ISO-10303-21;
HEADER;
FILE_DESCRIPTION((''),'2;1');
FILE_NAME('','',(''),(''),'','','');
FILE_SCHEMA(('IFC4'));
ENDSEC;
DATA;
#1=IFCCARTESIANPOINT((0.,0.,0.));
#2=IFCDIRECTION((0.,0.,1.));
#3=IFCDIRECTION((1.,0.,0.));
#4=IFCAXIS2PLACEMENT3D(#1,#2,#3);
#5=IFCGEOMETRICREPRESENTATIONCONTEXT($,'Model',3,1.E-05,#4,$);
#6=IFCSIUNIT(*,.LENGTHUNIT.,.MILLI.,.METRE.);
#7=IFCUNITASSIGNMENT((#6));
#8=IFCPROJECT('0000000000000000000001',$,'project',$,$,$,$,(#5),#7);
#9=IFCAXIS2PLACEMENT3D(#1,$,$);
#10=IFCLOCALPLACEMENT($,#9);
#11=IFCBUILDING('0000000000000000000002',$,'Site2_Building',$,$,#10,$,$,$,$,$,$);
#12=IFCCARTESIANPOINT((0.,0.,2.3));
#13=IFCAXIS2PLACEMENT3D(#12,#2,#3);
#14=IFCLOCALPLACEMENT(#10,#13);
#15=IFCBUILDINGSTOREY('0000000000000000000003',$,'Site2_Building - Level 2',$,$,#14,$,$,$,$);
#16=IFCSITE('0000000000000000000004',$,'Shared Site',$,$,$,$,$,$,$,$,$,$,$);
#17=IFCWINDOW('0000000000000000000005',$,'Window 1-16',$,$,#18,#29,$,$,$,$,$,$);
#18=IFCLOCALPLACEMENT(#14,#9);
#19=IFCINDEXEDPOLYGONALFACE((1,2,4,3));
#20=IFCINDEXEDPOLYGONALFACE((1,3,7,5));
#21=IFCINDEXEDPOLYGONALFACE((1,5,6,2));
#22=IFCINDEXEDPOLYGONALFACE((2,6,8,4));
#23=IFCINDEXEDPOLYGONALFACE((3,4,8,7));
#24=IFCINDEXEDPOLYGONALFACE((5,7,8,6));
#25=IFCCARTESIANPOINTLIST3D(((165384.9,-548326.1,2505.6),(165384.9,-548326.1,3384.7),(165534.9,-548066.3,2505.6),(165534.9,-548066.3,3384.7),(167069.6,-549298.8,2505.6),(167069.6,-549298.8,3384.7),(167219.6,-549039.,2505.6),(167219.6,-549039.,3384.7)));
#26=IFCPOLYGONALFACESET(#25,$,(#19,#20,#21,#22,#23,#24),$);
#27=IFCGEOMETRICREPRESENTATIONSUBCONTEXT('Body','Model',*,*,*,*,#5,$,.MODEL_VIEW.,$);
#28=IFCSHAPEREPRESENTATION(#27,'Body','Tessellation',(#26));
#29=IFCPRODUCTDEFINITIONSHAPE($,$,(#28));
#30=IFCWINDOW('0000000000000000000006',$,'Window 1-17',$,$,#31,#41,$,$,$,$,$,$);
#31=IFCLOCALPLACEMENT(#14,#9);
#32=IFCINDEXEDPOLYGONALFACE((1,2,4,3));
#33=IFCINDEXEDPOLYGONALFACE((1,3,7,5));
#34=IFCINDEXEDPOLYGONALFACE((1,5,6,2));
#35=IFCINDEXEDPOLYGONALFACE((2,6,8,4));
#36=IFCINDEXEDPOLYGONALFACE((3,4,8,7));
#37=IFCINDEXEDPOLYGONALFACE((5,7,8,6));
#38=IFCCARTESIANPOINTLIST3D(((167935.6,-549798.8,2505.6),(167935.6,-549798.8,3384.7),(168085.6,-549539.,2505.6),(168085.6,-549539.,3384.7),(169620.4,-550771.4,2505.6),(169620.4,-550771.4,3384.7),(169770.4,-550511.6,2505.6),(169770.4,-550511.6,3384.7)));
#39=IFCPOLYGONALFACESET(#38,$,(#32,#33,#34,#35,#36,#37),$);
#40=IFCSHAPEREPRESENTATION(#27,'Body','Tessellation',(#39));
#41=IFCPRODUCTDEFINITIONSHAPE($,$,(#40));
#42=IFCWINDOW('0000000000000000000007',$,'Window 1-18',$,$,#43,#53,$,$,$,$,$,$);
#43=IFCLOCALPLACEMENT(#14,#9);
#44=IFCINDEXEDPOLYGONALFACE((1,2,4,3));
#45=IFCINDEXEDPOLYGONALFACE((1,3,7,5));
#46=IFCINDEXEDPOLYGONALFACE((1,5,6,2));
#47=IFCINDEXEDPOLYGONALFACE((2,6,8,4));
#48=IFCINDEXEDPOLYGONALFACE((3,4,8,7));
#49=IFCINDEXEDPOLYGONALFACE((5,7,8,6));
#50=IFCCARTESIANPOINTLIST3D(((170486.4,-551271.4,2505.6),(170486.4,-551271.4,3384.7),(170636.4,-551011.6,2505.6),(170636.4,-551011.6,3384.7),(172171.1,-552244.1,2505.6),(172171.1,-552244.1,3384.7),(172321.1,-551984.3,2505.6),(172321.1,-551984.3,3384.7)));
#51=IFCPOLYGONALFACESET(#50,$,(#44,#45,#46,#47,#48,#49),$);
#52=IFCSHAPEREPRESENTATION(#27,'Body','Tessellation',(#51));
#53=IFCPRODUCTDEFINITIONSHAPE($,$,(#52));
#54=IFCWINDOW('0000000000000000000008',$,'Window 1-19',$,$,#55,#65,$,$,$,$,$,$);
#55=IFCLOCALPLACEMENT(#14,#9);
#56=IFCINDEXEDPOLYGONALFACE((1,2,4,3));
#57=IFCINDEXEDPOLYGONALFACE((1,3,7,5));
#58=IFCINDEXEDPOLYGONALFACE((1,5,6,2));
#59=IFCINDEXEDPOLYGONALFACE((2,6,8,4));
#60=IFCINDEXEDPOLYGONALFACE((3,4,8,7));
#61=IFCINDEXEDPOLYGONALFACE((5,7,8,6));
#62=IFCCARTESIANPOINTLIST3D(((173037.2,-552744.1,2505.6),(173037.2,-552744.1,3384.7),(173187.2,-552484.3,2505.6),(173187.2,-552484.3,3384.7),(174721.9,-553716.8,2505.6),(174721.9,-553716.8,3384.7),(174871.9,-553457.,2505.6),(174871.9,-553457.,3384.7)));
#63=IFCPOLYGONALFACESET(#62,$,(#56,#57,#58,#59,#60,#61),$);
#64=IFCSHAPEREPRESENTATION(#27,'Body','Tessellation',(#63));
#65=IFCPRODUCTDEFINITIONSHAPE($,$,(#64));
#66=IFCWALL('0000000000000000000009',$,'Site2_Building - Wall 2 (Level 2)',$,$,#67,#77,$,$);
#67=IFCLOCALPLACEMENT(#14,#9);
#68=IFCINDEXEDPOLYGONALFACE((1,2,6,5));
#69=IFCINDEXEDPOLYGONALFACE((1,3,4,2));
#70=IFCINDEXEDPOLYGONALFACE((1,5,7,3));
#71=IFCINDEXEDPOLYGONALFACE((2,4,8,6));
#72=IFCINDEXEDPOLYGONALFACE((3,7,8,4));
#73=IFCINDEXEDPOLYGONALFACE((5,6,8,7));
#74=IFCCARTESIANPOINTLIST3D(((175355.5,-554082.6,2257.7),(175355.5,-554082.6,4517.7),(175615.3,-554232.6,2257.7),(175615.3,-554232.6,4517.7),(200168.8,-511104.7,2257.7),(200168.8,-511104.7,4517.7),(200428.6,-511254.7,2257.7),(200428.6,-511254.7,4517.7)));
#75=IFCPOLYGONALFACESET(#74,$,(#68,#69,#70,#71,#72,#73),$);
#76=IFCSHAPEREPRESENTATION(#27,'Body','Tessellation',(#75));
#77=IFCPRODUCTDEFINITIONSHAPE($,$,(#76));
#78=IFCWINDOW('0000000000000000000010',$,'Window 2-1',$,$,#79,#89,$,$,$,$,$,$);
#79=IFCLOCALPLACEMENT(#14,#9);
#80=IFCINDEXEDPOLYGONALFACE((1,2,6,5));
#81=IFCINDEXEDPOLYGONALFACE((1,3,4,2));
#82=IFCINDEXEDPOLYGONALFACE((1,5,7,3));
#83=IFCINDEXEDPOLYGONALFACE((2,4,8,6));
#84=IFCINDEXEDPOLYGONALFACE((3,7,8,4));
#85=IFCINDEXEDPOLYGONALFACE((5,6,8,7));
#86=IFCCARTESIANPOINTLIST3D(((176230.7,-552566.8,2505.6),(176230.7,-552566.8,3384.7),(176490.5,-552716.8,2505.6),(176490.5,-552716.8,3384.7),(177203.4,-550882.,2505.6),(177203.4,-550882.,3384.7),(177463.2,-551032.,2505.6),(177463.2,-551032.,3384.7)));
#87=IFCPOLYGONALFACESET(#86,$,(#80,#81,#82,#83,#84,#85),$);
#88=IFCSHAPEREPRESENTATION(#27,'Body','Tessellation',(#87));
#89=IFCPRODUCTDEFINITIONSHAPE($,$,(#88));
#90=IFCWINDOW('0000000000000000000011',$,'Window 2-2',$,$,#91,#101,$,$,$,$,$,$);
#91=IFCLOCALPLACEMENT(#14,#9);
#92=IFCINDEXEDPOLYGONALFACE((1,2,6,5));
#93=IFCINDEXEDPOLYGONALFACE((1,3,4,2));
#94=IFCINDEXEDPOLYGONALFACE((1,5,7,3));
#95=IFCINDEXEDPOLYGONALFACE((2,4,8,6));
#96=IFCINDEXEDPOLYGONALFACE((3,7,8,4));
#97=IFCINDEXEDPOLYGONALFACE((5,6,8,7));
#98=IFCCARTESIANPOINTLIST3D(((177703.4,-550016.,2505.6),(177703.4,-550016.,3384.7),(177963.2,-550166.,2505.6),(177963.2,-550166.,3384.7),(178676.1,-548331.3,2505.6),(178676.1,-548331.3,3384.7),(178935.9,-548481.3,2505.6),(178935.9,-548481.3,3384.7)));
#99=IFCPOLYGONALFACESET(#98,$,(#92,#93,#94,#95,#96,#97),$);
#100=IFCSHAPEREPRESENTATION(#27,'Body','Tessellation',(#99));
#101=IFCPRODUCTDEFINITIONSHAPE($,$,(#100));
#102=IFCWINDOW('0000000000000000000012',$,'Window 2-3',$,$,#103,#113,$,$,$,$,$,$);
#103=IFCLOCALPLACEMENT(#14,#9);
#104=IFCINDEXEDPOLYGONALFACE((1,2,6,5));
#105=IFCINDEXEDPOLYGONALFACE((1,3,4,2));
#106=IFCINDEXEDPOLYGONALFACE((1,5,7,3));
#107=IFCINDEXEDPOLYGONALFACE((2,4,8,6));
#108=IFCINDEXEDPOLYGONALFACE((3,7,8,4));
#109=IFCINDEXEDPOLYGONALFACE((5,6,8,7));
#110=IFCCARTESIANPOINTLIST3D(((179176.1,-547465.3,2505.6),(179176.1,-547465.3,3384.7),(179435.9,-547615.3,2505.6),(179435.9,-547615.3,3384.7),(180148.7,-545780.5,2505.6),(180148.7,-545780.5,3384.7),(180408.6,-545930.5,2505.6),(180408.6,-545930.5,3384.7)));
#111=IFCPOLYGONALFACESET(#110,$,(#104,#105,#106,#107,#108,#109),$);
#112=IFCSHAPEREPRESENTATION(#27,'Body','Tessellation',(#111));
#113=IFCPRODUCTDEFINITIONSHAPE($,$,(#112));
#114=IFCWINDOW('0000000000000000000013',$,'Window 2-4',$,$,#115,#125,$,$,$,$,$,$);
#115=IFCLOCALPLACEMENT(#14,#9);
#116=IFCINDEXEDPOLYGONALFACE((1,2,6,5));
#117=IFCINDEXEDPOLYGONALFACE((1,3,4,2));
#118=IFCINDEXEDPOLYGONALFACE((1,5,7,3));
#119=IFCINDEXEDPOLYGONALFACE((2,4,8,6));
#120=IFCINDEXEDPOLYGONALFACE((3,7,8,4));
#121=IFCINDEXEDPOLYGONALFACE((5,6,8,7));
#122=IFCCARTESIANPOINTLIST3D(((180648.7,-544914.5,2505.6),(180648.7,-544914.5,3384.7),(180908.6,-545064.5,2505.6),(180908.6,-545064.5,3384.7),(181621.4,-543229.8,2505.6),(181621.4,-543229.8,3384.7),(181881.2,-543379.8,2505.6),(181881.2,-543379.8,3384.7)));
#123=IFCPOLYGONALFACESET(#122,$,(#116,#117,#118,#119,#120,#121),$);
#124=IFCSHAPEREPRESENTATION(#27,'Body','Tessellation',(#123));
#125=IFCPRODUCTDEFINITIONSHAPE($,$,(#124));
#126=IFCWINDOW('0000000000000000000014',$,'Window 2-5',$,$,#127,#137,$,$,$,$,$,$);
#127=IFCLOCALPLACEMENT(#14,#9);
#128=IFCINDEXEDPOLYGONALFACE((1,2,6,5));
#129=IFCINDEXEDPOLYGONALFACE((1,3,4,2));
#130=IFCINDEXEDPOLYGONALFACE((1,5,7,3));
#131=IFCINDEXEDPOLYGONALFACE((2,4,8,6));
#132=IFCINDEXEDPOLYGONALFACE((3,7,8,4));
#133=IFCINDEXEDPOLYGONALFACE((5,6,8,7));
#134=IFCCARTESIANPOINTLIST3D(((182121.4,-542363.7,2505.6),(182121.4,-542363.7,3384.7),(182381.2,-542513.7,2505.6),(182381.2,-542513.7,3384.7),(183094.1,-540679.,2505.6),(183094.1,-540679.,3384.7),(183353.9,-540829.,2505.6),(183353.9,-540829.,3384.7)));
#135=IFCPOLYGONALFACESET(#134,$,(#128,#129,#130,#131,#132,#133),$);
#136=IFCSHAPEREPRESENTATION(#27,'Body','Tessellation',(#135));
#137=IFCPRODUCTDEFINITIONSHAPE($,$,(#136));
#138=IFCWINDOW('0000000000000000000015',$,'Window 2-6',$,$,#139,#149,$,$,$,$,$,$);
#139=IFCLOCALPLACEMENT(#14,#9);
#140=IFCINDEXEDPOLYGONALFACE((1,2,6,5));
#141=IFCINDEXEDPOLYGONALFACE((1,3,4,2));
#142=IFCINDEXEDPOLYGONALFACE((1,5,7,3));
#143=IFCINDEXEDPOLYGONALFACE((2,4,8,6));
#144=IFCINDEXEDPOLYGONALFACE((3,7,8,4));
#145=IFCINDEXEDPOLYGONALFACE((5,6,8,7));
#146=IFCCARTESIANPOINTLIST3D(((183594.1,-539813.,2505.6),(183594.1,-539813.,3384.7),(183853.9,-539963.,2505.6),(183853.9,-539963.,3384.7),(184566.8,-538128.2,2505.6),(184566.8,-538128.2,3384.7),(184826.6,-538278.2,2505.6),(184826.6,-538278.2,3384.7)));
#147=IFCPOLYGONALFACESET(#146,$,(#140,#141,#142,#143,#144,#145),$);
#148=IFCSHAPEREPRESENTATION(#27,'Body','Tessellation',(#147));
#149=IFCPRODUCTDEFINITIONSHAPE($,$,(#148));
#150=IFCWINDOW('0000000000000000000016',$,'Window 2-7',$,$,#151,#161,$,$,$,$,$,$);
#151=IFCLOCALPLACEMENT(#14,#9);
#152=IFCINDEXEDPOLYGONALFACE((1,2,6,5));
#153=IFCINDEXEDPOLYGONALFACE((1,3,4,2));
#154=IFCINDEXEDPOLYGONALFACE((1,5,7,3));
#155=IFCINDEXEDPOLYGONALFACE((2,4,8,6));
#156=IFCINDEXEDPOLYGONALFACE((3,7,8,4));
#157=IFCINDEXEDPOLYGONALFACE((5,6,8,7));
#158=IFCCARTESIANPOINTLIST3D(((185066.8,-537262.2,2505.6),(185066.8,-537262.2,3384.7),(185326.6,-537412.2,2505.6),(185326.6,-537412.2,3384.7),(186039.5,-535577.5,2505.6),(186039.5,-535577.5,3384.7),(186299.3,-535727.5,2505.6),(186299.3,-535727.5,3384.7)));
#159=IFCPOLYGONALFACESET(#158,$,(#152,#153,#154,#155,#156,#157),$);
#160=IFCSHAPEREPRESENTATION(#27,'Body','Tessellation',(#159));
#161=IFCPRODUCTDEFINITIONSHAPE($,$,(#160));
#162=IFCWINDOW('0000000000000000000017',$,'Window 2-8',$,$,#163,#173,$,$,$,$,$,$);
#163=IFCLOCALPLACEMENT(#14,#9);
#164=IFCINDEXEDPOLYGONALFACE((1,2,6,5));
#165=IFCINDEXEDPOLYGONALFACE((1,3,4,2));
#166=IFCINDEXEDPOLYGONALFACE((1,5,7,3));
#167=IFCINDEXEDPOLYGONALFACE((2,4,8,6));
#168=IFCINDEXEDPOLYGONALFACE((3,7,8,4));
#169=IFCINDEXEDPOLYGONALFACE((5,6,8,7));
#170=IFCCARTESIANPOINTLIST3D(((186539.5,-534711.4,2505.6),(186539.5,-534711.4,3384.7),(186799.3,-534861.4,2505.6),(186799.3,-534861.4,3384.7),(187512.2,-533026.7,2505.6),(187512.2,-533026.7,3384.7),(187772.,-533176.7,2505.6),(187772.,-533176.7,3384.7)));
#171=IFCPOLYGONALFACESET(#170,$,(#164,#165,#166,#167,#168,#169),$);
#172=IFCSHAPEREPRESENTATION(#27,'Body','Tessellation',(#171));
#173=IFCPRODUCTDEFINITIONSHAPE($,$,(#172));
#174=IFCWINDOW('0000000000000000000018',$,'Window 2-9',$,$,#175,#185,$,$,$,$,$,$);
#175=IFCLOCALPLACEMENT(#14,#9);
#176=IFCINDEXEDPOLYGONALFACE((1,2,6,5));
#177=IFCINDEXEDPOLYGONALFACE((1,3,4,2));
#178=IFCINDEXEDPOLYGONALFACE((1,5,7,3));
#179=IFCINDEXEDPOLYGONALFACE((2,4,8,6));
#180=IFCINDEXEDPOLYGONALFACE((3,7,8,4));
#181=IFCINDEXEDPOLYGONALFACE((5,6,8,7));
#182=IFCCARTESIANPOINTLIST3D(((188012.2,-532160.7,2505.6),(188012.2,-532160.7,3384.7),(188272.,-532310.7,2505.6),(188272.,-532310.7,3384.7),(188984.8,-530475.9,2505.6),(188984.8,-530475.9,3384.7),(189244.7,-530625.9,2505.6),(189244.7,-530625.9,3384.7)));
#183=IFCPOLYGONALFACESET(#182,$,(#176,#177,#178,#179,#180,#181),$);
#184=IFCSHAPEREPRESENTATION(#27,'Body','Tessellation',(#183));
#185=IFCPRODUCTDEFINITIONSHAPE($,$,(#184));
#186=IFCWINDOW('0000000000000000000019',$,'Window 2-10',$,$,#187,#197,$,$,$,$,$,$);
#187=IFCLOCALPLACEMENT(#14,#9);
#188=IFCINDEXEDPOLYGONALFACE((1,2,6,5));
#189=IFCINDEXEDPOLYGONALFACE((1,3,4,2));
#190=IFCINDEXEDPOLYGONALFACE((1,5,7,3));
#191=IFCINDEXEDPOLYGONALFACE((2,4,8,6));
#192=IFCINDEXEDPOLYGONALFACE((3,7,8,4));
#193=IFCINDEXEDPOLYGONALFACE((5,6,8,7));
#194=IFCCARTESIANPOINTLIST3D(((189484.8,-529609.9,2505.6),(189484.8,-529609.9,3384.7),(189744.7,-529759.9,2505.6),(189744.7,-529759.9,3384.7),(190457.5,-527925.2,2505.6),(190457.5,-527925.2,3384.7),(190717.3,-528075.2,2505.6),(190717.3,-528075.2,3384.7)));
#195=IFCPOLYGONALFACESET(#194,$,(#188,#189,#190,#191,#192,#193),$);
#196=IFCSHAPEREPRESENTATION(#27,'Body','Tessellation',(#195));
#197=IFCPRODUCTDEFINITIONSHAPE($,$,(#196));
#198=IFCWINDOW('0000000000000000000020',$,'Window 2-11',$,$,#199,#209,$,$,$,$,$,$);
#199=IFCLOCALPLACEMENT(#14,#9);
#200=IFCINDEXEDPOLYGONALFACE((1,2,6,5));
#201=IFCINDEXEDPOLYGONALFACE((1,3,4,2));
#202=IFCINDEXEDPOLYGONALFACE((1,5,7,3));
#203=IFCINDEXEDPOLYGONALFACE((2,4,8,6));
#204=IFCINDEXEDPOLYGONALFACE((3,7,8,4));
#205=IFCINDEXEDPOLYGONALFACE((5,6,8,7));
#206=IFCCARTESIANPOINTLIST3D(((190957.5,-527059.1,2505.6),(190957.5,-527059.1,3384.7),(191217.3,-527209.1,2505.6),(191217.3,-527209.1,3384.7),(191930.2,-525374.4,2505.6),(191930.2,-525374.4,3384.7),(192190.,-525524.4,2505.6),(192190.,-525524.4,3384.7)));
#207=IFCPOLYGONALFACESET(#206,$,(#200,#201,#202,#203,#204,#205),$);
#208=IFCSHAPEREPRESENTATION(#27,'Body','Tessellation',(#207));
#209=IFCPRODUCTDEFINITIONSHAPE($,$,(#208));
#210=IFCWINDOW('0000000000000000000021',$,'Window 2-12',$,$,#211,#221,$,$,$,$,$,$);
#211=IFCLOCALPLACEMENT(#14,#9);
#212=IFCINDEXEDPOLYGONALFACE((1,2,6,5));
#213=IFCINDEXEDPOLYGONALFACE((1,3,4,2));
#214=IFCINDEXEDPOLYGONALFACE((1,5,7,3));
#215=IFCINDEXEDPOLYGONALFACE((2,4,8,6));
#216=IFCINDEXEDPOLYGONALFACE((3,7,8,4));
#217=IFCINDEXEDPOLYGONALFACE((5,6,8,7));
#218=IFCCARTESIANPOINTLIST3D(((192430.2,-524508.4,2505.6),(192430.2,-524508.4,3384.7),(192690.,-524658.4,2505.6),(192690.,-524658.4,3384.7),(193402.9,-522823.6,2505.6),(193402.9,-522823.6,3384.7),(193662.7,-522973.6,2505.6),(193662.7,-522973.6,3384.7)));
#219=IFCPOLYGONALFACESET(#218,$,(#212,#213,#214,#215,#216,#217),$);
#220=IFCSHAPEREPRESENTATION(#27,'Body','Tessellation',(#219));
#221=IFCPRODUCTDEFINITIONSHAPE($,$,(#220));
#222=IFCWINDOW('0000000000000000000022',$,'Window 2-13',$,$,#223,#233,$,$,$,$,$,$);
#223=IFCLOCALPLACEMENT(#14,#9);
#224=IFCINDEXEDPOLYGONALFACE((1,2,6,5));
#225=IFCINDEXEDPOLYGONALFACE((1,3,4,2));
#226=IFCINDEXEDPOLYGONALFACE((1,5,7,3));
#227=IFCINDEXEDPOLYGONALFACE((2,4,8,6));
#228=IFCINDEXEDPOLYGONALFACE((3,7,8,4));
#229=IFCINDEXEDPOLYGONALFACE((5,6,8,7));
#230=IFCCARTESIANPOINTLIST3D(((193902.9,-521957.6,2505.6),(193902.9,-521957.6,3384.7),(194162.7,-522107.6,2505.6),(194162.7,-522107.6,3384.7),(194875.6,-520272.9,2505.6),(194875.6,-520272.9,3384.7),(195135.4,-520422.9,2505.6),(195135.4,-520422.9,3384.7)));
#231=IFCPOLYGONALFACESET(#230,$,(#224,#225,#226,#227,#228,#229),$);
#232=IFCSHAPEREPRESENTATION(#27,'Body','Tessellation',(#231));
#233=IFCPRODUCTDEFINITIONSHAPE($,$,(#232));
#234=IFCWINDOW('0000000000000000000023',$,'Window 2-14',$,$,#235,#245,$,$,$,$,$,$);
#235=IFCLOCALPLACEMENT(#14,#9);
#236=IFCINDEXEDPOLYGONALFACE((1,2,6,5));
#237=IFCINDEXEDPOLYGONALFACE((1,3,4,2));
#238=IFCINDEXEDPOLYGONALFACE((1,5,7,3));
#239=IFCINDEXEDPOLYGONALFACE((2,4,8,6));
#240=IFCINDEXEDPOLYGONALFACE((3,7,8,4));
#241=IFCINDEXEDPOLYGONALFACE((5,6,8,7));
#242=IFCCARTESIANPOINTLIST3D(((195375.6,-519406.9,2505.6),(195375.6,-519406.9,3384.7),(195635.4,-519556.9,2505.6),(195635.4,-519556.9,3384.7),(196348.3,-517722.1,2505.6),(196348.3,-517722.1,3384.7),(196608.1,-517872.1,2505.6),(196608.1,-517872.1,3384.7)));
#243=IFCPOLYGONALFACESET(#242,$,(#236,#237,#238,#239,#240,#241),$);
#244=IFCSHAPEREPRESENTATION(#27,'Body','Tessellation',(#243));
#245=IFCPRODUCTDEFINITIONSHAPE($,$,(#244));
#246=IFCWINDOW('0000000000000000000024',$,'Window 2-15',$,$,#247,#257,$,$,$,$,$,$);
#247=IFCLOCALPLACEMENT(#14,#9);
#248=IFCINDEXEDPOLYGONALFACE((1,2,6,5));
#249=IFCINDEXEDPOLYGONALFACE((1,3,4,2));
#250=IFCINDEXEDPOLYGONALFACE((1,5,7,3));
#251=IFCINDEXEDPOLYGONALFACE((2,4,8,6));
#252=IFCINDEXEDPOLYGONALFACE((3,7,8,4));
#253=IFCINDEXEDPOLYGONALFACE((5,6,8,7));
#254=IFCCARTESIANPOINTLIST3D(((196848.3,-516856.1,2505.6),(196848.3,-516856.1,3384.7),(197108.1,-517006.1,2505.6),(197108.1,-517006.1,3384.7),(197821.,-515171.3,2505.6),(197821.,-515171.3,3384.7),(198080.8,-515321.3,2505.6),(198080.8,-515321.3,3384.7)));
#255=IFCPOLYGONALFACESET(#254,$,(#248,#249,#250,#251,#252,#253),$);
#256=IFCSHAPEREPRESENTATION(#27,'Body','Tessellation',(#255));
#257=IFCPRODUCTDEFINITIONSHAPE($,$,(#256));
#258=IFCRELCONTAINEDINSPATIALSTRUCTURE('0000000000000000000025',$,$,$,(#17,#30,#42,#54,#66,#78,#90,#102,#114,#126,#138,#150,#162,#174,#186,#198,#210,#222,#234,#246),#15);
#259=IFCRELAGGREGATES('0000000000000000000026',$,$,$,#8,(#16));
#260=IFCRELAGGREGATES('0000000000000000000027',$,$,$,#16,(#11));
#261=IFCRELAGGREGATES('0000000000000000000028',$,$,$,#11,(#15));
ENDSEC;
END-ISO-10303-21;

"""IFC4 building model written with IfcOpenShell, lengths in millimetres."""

from ifc_helpers import new_model, si_unit, frame, origin, origin_with_axes, place, context, subcontext, project, spatial, indexed_curve, outline, extrude, element, save


model = new_model("IFC4")

# Units and contexts
model_context = context("Model", 3, precision=1e-05, world=origin_with_axes())
body_context = subcontext(model_context, "Body", "Model", "MODEL_VIEW")
ifc_project = project(units=[si_unit("LENGTHUNIT", "METRE", prefix="MILLI")], contexts=[model_context])

# Site, building, storey
site = spatial("IfcSite", under=ifc_project, Name="Shared Site")
building_placement = place(None, origin())
building = spatial("IfcBuilding", under=site, at=building_placement, Name="Site2_Building")
storey_placement = place(building_placement, frame((0.0, 0.0, 2.3), z_axis=(0.0, 0.0, 1.0), x_axis=(1.0, 0.0, 0.0)))
storey = spatial("IfcBuildingStorey", under=building, at=storey_placement, Name="Site2_Building - Level 2")

# Windows
for number, where, z_axis, x_axis, name in (
    (1, (165384.9, -548326.1, 2505.6), (0.0, 0.0, 1.0), (0.866025, -0.5, 0.0), "Window 1-16"),
    (2, (167935.6, -549798.8, 2505.6), (0.0, 0.0, 1.0), (0.866025, -0.5, 0.0), "Window 1-17"),
    (3, (170486.4, -551271.4, 2505.6), (0.0, 0.0, 1.0), (0.866025, -0.5, 0.0), "Window 1-18"),
    (4, (173037.2, -552744.1, 2505.6), (0.0, 0.0, 1.0), (0.866025, -0.5, 0.0), "Window 1-19"),
):
    element("IfcWindow", number, at=place(storey_placement, frame(where, z_axis=z_axis, x_axis=x_axis)), inside=storey, Name=name, context=body_context, shape_type="SweptSolid", body=[
        extrude(outline(indexed_curve([(0.0, 0.0), (0.0, 300.0), (1945.4, 300.0), (1945.4, 0.0), (0.0, 0.0)], self_intersect=False)), origin_with_axes(), (0.0, 0.0, 1.0), 879.1),
    ])

# Wall
wall_1_placement = place(storey_placement, frame((175615.3, -554232.6, 2257.7), z_axis=(0.0, 0.0, 1.0), x_axis=(0.5, 0.866025, 0.0)))
element("IfcWall", 5, at=wall_1_placement, inside=storey, Name="Site2_Building - Wall 2 (Level 2)", context=body_context, shape_type="SweptSolid", body=[
    extrude(outline(indexed_curve([(0.0, 0.0), (0.0, 300.0), (49626.6, 300.0), (49626.6, 0.0), (0.0, 0.0)], self_intersect=False)), origin_with_axes(), (0.0, 0.0, 1.0), 2260.0),
])

# Windows
for number, where, z_axis, x_axis, name in (
    (6, (176490.5, -552716.8, 2505.6), (0.0, 0.0, 1.0), (0.5, 0.866025, 0.0), "Window 2-1"),
    (7, (177963.2, -550166.0, 2505.6), (0.0, 0.0, 1.0), (0.5, 0.866025, 0.0), "Window 2-2"),
    (8, (179435.9, -547615.3, 2505.6), (0.0, 0.0, 1.0), (0.5, 0.866025, 0.0), "Window 2-3"),
    (9, (180908.6, -545064.5, 2505.6), (0.0, 0.0, 1.0), (0.5, 0.866025, 0.0), "Window 2-4"),
    (10, (182381.2, -542513.7, 2505.6), (0.0, 0.0, 1.0), (0.5, 0.866025, 0.0), "Window 2-5"),
    (11, (183853.9, -539963.0, 2505.6), (0.0, 0.0, 1.0), (0.5, 0.866025, 0.0), "Window 2-6"),
    (12, (185326.6, -537412.2, 2505.6), (0.0, 0.0, 1.0), (0.5, 0.866025, 0.0), "Window 2-7"),
    (13, (186799.3, -534861.4, 2505.6), (0.0, 0.0, 1.0), (0.5, 0.866025, 0.0), "Window 2-8"),
    (14, (188272.0, -532310.7, 2505.6), (0.0, 0.0, 1.0), (0.5, 0.866025, 0.0), "Window 2-9"),
    (15, (189744.7, -529759.9, 2505.6), (0.0, 0.0, 1.0), (0.5, 0.866025, 0.0), "Window 2-10"),
    (16, (191217.3, -527209.1, 2505.6), (0.0, 0.0, 1.0), (0.5, 0.866025, 0.0), "Window 2-11"),
    (17, (192690.0, -524658.4, 2505.6), (0.0, 0.0, 1.0), (0.5, 0.866025, 0.0), "Window 2-12"),
    (18, (194162.7, -522107.6, 2505.6), (0.0, 0.0, 1.0), (0.5, 0.866025, 0.0), "Window 2-13"),
    (19, (195635.4, -519556.9, 2505.6), (0.0, 0.0, 1.0), (0.5, 0.866025, 0.0), "Window 2-14"),
    (20, (197108.1, -517006.1, 2505.6), (0.0, 0.0, 1.0), (0.5, 0.866025, 0.0), "Window 2-15"),
):
    element("IfcWindow", number, at=place(storey_placement, frame(where, z_axis=z_axis, x_axis=x_axis)), inside=storey, Name=name, context=body_context, shape_type="SweptSolid", body=[
        extrude(outline(indexed_curve([(0.0, 0.0), (0.0, 300.0), (1945.4, 300.0), (1945.4, 0.0), (0.0, 0.0)], self_intersect=False)), origin_with_axes(), (0.0, 0.0, 1.0), 879.1),
    ])

save(model, "model.ifc")
